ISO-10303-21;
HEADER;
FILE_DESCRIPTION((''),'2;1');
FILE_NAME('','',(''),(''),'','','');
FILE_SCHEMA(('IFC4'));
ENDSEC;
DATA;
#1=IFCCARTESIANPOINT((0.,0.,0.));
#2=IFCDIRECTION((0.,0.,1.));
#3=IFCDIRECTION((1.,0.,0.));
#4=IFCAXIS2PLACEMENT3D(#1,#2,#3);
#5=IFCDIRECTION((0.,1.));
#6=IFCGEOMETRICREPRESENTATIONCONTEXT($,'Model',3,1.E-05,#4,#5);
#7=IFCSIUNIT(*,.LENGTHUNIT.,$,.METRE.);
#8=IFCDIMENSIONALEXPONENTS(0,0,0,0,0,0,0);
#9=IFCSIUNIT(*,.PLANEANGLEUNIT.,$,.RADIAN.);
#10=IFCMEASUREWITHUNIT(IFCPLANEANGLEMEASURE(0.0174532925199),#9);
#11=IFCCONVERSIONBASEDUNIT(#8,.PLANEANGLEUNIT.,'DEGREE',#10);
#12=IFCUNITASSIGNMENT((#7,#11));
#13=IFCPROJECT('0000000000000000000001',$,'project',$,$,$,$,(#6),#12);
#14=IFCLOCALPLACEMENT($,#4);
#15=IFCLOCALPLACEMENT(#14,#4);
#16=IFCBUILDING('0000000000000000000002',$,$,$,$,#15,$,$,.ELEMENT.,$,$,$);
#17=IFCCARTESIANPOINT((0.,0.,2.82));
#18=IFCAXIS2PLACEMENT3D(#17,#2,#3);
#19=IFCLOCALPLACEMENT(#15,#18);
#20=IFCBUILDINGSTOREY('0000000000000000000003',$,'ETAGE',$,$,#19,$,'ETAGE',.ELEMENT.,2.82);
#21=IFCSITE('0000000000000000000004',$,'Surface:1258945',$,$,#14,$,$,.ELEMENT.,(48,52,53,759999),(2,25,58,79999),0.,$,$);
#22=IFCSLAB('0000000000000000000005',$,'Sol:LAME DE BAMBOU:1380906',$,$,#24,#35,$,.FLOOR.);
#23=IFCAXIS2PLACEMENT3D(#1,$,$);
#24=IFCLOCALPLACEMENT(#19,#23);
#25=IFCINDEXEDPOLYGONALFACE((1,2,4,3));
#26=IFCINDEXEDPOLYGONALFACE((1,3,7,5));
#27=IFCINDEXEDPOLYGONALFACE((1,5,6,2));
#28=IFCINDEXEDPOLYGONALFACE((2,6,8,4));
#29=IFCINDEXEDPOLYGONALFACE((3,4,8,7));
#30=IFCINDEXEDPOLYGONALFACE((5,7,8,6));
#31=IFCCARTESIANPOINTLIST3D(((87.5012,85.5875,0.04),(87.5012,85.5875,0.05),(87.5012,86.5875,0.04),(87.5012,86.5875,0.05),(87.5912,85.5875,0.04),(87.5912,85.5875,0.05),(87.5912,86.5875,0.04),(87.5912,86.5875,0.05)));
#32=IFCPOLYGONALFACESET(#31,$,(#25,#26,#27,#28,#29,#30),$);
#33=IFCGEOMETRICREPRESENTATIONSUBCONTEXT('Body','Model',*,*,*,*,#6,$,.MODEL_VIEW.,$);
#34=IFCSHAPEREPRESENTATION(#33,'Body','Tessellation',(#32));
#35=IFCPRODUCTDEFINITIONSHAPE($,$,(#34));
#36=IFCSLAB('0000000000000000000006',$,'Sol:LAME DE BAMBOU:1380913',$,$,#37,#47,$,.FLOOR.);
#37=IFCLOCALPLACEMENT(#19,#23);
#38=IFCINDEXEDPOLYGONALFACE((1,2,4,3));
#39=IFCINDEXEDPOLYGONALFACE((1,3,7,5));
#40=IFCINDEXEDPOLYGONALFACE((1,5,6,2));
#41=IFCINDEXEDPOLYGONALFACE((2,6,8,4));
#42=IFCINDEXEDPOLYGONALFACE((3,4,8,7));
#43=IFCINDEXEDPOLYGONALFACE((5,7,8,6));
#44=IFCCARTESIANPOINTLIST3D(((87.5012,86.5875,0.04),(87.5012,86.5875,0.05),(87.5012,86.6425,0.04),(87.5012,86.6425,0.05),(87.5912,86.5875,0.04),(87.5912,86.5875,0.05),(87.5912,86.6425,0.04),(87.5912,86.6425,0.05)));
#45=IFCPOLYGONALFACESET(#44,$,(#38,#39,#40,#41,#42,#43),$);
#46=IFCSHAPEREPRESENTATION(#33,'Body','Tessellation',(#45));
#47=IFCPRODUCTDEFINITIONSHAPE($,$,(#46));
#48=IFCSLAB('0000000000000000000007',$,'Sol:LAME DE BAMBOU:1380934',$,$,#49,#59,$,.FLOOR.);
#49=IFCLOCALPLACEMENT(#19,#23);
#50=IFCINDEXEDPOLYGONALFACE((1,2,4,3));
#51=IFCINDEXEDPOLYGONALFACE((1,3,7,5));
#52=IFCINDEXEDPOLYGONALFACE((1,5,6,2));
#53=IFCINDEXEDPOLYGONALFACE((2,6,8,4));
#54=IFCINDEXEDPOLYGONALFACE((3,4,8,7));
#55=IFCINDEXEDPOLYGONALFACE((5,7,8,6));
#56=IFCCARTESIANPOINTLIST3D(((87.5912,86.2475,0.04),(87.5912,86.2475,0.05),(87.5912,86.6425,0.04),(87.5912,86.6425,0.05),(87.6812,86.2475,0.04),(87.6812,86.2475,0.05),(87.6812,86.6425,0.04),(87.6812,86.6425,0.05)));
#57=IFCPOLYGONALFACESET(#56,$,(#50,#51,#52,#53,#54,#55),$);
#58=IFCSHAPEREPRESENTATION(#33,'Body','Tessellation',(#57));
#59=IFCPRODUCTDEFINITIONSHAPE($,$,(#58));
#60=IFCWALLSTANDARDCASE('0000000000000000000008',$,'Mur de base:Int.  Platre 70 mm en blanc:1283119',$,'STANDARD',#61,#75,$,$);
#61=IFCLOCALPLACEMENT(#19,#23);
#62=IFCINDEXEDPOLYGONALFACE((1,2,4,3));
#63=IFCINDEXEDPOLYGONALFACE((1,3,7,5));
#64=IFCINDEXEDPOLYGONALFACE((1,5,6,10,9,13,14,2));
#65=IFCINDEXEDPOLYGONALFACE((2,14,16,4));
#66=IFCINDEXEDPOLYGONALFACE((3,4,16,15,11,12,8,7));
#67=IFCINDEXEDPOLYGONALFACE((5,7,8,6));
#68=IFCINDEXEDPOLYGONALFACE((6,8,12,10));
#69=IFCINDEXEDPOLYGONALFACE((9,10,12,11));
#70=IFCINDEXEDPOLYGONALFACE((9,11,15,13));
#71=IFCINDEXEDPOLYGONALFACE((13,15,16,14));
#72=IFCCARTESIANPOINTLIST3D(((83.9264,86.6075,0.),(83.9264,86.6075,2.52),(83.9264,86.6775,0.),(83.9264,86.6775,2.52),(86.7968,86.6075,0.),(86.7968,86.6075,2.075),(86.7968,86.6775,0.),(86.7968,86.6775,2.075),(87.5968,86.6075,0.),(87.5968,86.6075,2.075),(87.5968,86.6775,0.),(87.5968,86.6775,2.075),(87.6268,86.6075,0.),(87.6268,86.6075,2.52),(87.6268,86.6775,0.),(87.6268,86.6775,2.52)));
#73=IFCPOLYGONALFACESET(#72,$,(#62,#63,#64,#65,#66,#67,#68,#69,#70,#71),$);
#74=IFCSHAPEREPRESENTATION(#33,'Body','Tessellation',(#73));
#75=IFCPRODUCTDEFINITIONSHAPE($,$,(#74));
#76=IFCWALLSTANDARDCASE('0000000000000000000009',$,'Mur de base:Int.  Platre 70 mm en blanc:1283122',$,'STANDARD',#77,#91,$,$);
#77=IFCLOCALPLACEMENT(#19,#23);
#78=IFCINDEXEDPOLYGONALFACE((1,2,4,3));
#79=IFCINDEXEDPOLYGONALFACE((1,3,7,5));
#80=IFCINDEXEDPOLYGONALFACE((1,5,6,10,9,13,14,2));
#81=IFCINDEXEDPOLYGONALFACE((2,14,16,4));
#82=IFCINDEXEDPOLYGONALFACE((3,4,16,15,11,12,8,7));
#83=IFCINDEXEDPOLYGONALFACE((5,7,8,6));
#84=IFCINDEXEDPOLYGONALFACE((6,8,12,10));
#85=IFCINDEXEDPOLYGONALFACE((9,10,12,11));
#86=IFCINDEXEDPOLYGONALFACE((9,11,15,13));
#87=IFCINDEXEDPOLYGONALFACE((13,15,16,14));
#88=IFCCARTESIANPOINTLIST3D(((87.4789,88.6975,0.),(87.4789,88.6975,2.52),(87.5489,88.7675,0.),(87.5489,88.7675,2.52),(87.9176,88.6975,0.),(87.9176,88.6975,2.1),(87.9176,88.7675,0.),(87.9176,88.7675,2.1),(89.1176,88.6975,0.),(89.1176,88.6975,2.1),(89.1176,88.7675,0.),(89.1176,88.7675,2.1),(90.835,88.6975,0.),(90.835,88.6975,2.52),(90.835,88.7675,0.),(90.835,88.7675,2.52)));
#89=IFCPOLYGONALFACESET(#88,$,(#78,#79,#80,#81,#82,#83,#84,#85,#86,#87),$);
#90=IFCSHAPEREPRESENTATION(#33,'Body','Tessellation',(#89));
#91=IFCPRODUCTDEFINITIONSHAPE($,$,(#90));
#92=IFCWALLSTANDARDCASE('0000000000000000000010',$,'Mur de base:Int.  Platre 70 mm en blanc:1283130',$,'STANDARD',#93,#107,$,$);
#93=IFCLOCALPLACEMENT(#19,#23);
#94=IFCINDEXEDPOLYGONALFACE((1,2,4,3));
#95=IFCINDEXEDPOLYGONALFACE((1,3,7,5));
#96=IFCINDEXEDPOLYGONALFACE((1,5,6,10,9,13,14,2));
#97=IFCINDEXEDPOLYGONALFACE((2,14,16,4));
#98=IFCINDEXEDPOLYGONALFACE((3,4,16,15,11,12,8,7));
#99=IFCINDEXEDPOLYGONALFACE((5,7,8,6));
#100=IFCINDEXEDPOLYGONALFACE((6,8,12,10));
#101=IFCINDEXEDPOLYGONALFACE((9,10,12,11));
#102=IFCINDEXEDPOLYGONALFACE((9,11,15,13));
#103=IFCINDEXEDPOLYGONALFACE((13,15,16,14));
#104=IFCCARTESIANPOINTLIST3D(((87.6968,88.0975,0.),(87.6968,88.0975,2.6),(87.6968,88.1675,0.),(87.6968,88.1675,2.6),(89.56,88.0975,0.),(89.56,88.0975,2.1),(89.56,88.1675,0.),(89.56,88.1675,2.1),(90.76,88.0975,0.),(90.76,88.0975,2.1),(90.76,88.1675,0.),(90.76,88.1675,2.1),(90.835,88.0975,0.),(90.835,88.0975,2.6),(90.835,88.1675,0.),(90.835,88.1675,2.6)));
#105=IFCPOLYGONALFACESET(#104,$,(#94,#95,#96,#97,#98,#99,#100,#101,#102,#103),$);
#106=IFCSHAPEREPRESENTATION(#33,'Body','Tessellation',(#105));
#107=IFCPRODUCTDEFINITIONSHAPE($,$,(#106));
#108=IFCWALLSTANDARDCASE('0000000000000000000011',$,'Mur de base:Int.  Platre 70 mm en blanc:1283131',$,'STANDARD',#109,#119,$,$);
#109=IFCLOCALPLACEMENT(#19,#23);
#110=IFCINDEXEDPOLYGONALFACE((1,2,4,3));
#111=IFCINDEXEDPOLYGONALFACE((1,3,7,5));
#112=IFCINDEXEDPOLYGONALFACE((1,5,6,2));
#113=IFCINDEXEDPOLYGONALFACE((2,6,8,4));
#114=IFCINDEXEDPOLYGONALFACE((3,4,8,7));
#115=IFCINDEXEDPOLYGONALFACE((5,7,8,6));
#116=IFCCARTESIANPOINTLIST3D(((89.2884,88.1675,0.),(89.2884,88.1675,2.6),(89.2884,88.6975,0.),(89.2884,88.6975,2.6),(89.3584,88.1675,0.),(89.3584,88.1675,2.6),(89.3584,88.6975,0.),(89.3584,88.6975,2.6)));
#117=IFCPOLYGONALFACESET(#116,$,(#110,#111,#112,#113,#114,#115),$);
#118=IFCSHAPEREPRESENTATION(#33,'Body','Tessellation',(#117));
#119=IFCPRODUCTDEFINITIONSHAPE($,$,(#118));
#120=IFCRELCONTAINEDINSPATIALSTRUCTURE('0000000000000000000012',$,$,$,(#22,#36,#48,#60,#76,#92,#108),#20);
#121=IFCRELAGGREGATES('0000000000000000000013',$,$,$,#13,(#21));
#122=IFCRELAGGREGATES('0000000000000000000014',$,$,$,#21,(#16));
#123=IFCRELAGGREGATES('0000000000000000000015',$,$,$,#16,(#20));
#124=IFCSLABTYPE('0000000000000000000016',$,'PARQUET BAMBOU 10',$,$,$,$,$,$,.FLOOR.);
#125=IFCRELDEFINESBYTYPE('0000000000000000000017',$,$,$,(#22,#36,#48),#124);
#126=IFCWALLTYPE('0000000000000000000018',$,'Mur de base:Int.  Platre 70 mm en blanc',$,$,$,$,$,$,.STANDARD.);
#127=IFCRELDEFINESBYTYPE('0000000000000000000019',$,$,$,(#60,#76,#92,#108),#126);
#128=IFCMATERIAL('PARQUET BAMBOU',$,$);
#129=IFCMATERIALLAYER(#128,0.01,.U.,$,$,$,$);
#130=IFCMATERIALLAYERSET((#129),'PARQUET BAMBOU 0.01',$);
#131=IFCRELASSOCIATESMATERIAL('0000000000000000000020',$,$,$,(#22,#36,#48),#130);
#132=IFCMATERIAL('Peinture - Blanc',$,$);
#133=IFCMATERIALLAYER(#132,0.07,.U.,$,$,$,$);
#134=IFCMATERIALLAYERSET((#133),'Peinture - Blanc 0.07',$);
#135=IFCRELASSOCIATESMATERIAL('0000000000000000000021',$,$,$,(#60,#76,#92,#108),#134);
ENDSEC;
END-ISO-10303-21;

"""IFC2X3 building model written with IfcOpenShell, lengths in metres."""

from ifc_helpers import new_model, entity, si_unit, converted_unit, direction, frame, origin_with_axes, place, context, subcontext, project, spatial, polyline, outline, extrude, material, layer, layer_set, layer_usage, type_object, element, save


model = new_model("IFC2X3")

# Units and contexts
model_context = context("Model", 3, precision=1e-05, world=origin_with_axes(), true_north=direction((0.0, 1.0)))
body_context = subcontext(model_context, "Body", "Model", "MODEL_VIEW")
ifc_project = project(units=[si_unit("LENGTHUNIT", "METRE"), converted_unit("PLANEANGLEUNIT", "DEGREE", entity("IfcPlaneAngleMeasure", 0.0174532925199), si_unit("PLANEANGLEUNIT", "RADIAN"), dimensions=[0, 0, 0, 0, 0, 0, 0])], contexts=[model_context])

# Site, building, storey
site_placement = place(None, origin_with_axes())
site = spatial("IfcSite", under=ifc_project, at=site_placement, Name="Surface:1258945", CompositionType="ELEMENT", RefLatitude=(48, 52, 53, 759999), RefLongitude=(2, 25, 58, 79999), RefElevation=0.0)
building_placement = place(site_placement, origin_with_axes())
building = spatial("IfcBuilding", under=site, at=building_placement, CompositionType="ELEMENT")
storey_placement = place(building_placement, frame((0.0, 0.0, 2.82), z_axis=(0.0, 0.0, 1.0), x_axis=(1.0, 0.0, 0.0)))
storey = spatial("IfcBuildingStorey", under=building, at=storey_placement, Name="ETAGE", LongName="ETAGE", CompositionType="ELEMENT", Elevation=2.82)

# Slabs
ifc_material_1 = material(Name="PARQUET BAMBOU")
ifc_layer_1 = layer(ifc_material_1, 0.01, ventilated="UNKNOWN")
ifc_layer_set_1 = layer_set([ifc_layer_1], Name="PARQUET BAMBOU 0.01")
slab_type = type_object("IfcSlabType", Name="PARQUET BAMBOU 10", PredefinedType="FLOOR")
ifc_layer_usage_1 = layer_usage(ifc_layer_set_1, "AXIS3", "NEGATIVE", 0.01)
slab_1_placement = place(storey_placement, frame((87.5012, 86.5875, 0.05), z_axis=(0.0, 0.0, 1.0), x_axis=(1.0, 0.0, 0.0)))
element("IfcSlab", 1, at=slab_1_placement, inside=storey, type_object=slab_type, material=ifc_layer_usage_1, Name="Sol:LAME DE BAMBOU:1380906", PredefinedType="FLOOR", context=body_context, shape_type="SweptSolid", body=[
    extrude(outline(polyline([(0.0, 0.0), (0.0, -1.0), (0.09, -1.0), (0.09, 0.0), (0.0, 0.0)])), frame((0.0, 0.0, -0.01), z_axis=(0.0, 0.0, 1.0), x_axis=(1.0, 0.0, 0.0)), (0.0, 0.0, 1.0), 0.01),
])
ifc_layer_usage_2 = layer_usage(ifc_layer_set_1, "AXIS3", "NEGATIVE", 0.01)
slab_2_placement = place(storey_placement, frame((87.5012, 86.6425, 0.05), z_axis=(0.0, 0.0, 1.0), x_axis=(1.0, 0.0, 0.0)))
element("IfcSlab", 2, at=slab_2_placement, inside=storey, type_object=slab_type, material=ifc_layer_usage_2, Name="Sol:LAME DE BAMBOU:1380913", PredefinedType="FLOOR", context=body_context, shape_type="SweptSolid", body=[
    extrude(outline(polyline([(0.0, 0.0), (0.0, -0.055), (0.09, -0.055), (0.09, 0.0), (0.0, 0.0)])), frame((0.0, 0.0, -0.01), z_axis=(0.0, 0.0, 1.0), x_axis=(1.0, 0.0, 0.0)), (0.0, 0.0, 1.0), 0.01),
])
ifc_layer_usage_3 = layer_usage(ifc_layer_set_1, "AXIS3", "NEGATIVE", 0.01)
slab_3_placement = place(storey_placement, frame((87.5912, 86.6425, 0.05), z_axis=(0.0, 0.0, 1.0), x_axis=(1.0, 0.0, 0.0)))
element("IfcSlab", 3, at=slab_3_placement, inside=storey, type_object=slab_type, material=ifc_layer_usage_3, Name="Sol:LAME DE BAMBOU:1380934", PredefinedType="FLOOR", context=body_context, shape_type="SweptSolid", body=[
    extrude(outline(polyline([(0.0, 0.0), (0.0, -0.395), (0.09, -0.395), (0.09, 0.0), (0.0, 0.0)])), frame((0.0, 0.0, -0.01), z_axis=(0.0, 0.0, 1.0), x_axis=(1.0, 0.0, 0.0)), (0.0, 0.0, 1.0), 0.01),
])

# Walls, openings
ifc_material_2 = material(Name="Peinture - Blanc")
ifc_layer_2 = layer(ifc_material_2, 0.07, ventilated="UNKNOWN")
ifc_layer_set_2 = layer_set([ifc_layer_2], Name="Peinture - Blanc 0.07")
ifc_layer_usage_4 = layer_usage(ifc_layer_set_2, "AXIS2", "POSITIVE", -0.035)
wall_type_1 = type_object("IfcWallType", Name="Mur de base:Int.  Platre 70 mm en blanc", PredefinedType="STANDARD")
wall_1_placement = place(storey_placement, frame((87.6618, 86.6425, 0.0), z_axis=(0.0, 0.0, 1.0), x_axis=(-1.0, 0.0, 0.0)))
wall_1 = element("IfcWallStandardCase", 4, at=wall_1_placement, inside=storey, type_object=wall_type_1, material=ifc_layer_usage_4, Name="Mur de base:Int.  Platre 70 mm en blanc:1283119", ObjectType="STANDARD", context=body_context, shape_type="SweptSolid", body=[
    extrude(outline(polyline([(0.035, -0.035), (3.7354, -0.035), (3.7354, 0.035), (0.035, 0.035), (0.035, -0.035)])), origin_with_axes(), (0.0, 0.0, 1.0), 2.52),
])
opening_1_placement = place(wall_1_placement, frame((0.465, 0.0, 0.0), z_axis=(0.0, 0.0, 1.0), x_axis=(1.0, 0.0, 0.0)))
element("IfcOpeningElement", 5, at=opening_1_placement, cuts=wall_1, context=body_context, shape_type="SweptSolid", body=[
    extrude(outline(polyline([(-0.4, 0.0), (0.4, 0.0), (0.4, 2.075), (-0.4, 2.075), (-0.4, 0.0)])), frame((0.0, -0.035, 0.0), z_axis=(0.0, -1.0, 0.0), x_axis=(1.0, 0.0, 0.0)), (0.0, 0.0, -1.0), 0.07),
])
ifc_layer_usage_5 = layer_usage(ifc_layer_set_2, "AXIS2", "POSITIVE", -0.035)
wall_2_placement = place(storey_placement, frame((87.5139, 88.7325, 0.0), z_axis=(0.0, 0.0, 1.0), x_axis=(1.0, 0.0, 0.0)))
wall_2 = element("IfcWallStandardCase", 6, at=wall_2_placement, inside=storey, type_object=wall_type_1, material=ifc_layer_usage_5, Name="Mur de base:Int.  Platre 70 mm en blanc:1283122", ObjectType="STANDARD", context=body_context, shape_type="SweptSolid", body=[
    extrude(outline(polyline([(-0.035, -0.035), (3.3211, -0.035), (3.3211, 0.035), (0.035, 0.035), (-0.035, -0.035)])), origin_with_axes(), (0.0, 0.0, 1.0), 2.52),
])
opening_2_placement = place(wall_2_placement, frame((1.0037, 0.0, 0.0), z_axis=(0.0, 0.0, 1.0), x_axis=(1.0, 0.0, 0.0)))
element("IfcOpeningElement", 7, at=opening_2_placement, cuts=wall_2, context=body_context, shape_type="SweptSolid", body=[
    extrude(outline(polyline([(0.6, 0.0), (0.6, 2.1), (-0.6, 2.1), (-0.6, 0.0), (0.6, 0.0)])), frame((0.0, -0.035, 0.0), z_axis=(0.0, 1.0, 0.0), x_axis=(-1.0, 0.0, 0.0)), (0.0, 0.0, 1.0), 0.07),
])
ifc_layer_usage_6 = layer_usage(ifc_layer_set_2, "AXIS2", "POSITIVE", -0.035)
wall_3_placement = place(storey_placement, frame((87.6618, 88.1325, 0.0), z_axis=(0.0, 0.0, 1.0), x_axis=(1.0, 0.0, 0.0)))
wall_3 = element("IfcWallStandardCase", 8, at=wall_3_placement, inside=storey, type_object=wall_type_1, material=ifc_layer_usage_6, Name="Mur de base:Int.  Platre 70 mm en blanc:1283130", ObjectType="STANDARD", context=body_context, shape_type="SweptSolid", body=[
    extrude(outline(polyline([(0.035, -0.035), (3.1733, -0.035), (3.1733, 0.035), (0.035, 0.035), (0.035, -0.035)])), origin_with_axes(), (0.0, 0.0, 1.0), 2.6),
])
opening_3_placement = place(wall_3_placement, frame((2.4983, 0.0, 0.0), z_axis=(0.0, 0.0, 1.0), x_axis=(1.0, 0.0, 0.0)))
element("IfcOpeningElement", 9, at=opening_3_placement, cuts=wall_3, context=body_context, shape_type="SweptSolid", body=[
    extrude(outline(polyline([(0.6, 0.0), (0.6, 2.1), (-0.6, 2.1), (-0.6, 0.0), (0.6, 0.0)])), frame((0.0, -0.035, 0.0), z_axis=(0.0, 1.0, 0.0), x_axis=(-1.0, 0.0, 0.0)), (0.0, 0.0, 1.0), 0.07),
])

# Wall
ifc_layer_usage_7 = layer_usage(ifc_layer_set_2, "AXIS2", "POSITIVE", -0.035)
wall_4_placement = place(storey_placement, frame((89.3234, 88.1325, 0.0), z_axis=(0.0, 0.0, 1.0), x_axis=(0.0, 1.0, 0.0)))
element("IfcWallStandardCase", 10, at=wall_4_placement, inside=storey, type_object=wall_type_1, material=ifc_layer_usage_7, Name="Mur de base:Int.  Platre 70 mm en blanc:1283131", ObjectType="STANDARD", context=body_context, shape_type="SweptSolid", body=[
    extrude(outline(polyline([(0.035, -0.035), (0.565, -0.035), (0.565, 0.035), (0.035, 0.035), (0.035, -0.035)])), origin_with_axes(), (0.0, 0.0, 1.0), 2.6),
])

save(model, "model.ifc")
